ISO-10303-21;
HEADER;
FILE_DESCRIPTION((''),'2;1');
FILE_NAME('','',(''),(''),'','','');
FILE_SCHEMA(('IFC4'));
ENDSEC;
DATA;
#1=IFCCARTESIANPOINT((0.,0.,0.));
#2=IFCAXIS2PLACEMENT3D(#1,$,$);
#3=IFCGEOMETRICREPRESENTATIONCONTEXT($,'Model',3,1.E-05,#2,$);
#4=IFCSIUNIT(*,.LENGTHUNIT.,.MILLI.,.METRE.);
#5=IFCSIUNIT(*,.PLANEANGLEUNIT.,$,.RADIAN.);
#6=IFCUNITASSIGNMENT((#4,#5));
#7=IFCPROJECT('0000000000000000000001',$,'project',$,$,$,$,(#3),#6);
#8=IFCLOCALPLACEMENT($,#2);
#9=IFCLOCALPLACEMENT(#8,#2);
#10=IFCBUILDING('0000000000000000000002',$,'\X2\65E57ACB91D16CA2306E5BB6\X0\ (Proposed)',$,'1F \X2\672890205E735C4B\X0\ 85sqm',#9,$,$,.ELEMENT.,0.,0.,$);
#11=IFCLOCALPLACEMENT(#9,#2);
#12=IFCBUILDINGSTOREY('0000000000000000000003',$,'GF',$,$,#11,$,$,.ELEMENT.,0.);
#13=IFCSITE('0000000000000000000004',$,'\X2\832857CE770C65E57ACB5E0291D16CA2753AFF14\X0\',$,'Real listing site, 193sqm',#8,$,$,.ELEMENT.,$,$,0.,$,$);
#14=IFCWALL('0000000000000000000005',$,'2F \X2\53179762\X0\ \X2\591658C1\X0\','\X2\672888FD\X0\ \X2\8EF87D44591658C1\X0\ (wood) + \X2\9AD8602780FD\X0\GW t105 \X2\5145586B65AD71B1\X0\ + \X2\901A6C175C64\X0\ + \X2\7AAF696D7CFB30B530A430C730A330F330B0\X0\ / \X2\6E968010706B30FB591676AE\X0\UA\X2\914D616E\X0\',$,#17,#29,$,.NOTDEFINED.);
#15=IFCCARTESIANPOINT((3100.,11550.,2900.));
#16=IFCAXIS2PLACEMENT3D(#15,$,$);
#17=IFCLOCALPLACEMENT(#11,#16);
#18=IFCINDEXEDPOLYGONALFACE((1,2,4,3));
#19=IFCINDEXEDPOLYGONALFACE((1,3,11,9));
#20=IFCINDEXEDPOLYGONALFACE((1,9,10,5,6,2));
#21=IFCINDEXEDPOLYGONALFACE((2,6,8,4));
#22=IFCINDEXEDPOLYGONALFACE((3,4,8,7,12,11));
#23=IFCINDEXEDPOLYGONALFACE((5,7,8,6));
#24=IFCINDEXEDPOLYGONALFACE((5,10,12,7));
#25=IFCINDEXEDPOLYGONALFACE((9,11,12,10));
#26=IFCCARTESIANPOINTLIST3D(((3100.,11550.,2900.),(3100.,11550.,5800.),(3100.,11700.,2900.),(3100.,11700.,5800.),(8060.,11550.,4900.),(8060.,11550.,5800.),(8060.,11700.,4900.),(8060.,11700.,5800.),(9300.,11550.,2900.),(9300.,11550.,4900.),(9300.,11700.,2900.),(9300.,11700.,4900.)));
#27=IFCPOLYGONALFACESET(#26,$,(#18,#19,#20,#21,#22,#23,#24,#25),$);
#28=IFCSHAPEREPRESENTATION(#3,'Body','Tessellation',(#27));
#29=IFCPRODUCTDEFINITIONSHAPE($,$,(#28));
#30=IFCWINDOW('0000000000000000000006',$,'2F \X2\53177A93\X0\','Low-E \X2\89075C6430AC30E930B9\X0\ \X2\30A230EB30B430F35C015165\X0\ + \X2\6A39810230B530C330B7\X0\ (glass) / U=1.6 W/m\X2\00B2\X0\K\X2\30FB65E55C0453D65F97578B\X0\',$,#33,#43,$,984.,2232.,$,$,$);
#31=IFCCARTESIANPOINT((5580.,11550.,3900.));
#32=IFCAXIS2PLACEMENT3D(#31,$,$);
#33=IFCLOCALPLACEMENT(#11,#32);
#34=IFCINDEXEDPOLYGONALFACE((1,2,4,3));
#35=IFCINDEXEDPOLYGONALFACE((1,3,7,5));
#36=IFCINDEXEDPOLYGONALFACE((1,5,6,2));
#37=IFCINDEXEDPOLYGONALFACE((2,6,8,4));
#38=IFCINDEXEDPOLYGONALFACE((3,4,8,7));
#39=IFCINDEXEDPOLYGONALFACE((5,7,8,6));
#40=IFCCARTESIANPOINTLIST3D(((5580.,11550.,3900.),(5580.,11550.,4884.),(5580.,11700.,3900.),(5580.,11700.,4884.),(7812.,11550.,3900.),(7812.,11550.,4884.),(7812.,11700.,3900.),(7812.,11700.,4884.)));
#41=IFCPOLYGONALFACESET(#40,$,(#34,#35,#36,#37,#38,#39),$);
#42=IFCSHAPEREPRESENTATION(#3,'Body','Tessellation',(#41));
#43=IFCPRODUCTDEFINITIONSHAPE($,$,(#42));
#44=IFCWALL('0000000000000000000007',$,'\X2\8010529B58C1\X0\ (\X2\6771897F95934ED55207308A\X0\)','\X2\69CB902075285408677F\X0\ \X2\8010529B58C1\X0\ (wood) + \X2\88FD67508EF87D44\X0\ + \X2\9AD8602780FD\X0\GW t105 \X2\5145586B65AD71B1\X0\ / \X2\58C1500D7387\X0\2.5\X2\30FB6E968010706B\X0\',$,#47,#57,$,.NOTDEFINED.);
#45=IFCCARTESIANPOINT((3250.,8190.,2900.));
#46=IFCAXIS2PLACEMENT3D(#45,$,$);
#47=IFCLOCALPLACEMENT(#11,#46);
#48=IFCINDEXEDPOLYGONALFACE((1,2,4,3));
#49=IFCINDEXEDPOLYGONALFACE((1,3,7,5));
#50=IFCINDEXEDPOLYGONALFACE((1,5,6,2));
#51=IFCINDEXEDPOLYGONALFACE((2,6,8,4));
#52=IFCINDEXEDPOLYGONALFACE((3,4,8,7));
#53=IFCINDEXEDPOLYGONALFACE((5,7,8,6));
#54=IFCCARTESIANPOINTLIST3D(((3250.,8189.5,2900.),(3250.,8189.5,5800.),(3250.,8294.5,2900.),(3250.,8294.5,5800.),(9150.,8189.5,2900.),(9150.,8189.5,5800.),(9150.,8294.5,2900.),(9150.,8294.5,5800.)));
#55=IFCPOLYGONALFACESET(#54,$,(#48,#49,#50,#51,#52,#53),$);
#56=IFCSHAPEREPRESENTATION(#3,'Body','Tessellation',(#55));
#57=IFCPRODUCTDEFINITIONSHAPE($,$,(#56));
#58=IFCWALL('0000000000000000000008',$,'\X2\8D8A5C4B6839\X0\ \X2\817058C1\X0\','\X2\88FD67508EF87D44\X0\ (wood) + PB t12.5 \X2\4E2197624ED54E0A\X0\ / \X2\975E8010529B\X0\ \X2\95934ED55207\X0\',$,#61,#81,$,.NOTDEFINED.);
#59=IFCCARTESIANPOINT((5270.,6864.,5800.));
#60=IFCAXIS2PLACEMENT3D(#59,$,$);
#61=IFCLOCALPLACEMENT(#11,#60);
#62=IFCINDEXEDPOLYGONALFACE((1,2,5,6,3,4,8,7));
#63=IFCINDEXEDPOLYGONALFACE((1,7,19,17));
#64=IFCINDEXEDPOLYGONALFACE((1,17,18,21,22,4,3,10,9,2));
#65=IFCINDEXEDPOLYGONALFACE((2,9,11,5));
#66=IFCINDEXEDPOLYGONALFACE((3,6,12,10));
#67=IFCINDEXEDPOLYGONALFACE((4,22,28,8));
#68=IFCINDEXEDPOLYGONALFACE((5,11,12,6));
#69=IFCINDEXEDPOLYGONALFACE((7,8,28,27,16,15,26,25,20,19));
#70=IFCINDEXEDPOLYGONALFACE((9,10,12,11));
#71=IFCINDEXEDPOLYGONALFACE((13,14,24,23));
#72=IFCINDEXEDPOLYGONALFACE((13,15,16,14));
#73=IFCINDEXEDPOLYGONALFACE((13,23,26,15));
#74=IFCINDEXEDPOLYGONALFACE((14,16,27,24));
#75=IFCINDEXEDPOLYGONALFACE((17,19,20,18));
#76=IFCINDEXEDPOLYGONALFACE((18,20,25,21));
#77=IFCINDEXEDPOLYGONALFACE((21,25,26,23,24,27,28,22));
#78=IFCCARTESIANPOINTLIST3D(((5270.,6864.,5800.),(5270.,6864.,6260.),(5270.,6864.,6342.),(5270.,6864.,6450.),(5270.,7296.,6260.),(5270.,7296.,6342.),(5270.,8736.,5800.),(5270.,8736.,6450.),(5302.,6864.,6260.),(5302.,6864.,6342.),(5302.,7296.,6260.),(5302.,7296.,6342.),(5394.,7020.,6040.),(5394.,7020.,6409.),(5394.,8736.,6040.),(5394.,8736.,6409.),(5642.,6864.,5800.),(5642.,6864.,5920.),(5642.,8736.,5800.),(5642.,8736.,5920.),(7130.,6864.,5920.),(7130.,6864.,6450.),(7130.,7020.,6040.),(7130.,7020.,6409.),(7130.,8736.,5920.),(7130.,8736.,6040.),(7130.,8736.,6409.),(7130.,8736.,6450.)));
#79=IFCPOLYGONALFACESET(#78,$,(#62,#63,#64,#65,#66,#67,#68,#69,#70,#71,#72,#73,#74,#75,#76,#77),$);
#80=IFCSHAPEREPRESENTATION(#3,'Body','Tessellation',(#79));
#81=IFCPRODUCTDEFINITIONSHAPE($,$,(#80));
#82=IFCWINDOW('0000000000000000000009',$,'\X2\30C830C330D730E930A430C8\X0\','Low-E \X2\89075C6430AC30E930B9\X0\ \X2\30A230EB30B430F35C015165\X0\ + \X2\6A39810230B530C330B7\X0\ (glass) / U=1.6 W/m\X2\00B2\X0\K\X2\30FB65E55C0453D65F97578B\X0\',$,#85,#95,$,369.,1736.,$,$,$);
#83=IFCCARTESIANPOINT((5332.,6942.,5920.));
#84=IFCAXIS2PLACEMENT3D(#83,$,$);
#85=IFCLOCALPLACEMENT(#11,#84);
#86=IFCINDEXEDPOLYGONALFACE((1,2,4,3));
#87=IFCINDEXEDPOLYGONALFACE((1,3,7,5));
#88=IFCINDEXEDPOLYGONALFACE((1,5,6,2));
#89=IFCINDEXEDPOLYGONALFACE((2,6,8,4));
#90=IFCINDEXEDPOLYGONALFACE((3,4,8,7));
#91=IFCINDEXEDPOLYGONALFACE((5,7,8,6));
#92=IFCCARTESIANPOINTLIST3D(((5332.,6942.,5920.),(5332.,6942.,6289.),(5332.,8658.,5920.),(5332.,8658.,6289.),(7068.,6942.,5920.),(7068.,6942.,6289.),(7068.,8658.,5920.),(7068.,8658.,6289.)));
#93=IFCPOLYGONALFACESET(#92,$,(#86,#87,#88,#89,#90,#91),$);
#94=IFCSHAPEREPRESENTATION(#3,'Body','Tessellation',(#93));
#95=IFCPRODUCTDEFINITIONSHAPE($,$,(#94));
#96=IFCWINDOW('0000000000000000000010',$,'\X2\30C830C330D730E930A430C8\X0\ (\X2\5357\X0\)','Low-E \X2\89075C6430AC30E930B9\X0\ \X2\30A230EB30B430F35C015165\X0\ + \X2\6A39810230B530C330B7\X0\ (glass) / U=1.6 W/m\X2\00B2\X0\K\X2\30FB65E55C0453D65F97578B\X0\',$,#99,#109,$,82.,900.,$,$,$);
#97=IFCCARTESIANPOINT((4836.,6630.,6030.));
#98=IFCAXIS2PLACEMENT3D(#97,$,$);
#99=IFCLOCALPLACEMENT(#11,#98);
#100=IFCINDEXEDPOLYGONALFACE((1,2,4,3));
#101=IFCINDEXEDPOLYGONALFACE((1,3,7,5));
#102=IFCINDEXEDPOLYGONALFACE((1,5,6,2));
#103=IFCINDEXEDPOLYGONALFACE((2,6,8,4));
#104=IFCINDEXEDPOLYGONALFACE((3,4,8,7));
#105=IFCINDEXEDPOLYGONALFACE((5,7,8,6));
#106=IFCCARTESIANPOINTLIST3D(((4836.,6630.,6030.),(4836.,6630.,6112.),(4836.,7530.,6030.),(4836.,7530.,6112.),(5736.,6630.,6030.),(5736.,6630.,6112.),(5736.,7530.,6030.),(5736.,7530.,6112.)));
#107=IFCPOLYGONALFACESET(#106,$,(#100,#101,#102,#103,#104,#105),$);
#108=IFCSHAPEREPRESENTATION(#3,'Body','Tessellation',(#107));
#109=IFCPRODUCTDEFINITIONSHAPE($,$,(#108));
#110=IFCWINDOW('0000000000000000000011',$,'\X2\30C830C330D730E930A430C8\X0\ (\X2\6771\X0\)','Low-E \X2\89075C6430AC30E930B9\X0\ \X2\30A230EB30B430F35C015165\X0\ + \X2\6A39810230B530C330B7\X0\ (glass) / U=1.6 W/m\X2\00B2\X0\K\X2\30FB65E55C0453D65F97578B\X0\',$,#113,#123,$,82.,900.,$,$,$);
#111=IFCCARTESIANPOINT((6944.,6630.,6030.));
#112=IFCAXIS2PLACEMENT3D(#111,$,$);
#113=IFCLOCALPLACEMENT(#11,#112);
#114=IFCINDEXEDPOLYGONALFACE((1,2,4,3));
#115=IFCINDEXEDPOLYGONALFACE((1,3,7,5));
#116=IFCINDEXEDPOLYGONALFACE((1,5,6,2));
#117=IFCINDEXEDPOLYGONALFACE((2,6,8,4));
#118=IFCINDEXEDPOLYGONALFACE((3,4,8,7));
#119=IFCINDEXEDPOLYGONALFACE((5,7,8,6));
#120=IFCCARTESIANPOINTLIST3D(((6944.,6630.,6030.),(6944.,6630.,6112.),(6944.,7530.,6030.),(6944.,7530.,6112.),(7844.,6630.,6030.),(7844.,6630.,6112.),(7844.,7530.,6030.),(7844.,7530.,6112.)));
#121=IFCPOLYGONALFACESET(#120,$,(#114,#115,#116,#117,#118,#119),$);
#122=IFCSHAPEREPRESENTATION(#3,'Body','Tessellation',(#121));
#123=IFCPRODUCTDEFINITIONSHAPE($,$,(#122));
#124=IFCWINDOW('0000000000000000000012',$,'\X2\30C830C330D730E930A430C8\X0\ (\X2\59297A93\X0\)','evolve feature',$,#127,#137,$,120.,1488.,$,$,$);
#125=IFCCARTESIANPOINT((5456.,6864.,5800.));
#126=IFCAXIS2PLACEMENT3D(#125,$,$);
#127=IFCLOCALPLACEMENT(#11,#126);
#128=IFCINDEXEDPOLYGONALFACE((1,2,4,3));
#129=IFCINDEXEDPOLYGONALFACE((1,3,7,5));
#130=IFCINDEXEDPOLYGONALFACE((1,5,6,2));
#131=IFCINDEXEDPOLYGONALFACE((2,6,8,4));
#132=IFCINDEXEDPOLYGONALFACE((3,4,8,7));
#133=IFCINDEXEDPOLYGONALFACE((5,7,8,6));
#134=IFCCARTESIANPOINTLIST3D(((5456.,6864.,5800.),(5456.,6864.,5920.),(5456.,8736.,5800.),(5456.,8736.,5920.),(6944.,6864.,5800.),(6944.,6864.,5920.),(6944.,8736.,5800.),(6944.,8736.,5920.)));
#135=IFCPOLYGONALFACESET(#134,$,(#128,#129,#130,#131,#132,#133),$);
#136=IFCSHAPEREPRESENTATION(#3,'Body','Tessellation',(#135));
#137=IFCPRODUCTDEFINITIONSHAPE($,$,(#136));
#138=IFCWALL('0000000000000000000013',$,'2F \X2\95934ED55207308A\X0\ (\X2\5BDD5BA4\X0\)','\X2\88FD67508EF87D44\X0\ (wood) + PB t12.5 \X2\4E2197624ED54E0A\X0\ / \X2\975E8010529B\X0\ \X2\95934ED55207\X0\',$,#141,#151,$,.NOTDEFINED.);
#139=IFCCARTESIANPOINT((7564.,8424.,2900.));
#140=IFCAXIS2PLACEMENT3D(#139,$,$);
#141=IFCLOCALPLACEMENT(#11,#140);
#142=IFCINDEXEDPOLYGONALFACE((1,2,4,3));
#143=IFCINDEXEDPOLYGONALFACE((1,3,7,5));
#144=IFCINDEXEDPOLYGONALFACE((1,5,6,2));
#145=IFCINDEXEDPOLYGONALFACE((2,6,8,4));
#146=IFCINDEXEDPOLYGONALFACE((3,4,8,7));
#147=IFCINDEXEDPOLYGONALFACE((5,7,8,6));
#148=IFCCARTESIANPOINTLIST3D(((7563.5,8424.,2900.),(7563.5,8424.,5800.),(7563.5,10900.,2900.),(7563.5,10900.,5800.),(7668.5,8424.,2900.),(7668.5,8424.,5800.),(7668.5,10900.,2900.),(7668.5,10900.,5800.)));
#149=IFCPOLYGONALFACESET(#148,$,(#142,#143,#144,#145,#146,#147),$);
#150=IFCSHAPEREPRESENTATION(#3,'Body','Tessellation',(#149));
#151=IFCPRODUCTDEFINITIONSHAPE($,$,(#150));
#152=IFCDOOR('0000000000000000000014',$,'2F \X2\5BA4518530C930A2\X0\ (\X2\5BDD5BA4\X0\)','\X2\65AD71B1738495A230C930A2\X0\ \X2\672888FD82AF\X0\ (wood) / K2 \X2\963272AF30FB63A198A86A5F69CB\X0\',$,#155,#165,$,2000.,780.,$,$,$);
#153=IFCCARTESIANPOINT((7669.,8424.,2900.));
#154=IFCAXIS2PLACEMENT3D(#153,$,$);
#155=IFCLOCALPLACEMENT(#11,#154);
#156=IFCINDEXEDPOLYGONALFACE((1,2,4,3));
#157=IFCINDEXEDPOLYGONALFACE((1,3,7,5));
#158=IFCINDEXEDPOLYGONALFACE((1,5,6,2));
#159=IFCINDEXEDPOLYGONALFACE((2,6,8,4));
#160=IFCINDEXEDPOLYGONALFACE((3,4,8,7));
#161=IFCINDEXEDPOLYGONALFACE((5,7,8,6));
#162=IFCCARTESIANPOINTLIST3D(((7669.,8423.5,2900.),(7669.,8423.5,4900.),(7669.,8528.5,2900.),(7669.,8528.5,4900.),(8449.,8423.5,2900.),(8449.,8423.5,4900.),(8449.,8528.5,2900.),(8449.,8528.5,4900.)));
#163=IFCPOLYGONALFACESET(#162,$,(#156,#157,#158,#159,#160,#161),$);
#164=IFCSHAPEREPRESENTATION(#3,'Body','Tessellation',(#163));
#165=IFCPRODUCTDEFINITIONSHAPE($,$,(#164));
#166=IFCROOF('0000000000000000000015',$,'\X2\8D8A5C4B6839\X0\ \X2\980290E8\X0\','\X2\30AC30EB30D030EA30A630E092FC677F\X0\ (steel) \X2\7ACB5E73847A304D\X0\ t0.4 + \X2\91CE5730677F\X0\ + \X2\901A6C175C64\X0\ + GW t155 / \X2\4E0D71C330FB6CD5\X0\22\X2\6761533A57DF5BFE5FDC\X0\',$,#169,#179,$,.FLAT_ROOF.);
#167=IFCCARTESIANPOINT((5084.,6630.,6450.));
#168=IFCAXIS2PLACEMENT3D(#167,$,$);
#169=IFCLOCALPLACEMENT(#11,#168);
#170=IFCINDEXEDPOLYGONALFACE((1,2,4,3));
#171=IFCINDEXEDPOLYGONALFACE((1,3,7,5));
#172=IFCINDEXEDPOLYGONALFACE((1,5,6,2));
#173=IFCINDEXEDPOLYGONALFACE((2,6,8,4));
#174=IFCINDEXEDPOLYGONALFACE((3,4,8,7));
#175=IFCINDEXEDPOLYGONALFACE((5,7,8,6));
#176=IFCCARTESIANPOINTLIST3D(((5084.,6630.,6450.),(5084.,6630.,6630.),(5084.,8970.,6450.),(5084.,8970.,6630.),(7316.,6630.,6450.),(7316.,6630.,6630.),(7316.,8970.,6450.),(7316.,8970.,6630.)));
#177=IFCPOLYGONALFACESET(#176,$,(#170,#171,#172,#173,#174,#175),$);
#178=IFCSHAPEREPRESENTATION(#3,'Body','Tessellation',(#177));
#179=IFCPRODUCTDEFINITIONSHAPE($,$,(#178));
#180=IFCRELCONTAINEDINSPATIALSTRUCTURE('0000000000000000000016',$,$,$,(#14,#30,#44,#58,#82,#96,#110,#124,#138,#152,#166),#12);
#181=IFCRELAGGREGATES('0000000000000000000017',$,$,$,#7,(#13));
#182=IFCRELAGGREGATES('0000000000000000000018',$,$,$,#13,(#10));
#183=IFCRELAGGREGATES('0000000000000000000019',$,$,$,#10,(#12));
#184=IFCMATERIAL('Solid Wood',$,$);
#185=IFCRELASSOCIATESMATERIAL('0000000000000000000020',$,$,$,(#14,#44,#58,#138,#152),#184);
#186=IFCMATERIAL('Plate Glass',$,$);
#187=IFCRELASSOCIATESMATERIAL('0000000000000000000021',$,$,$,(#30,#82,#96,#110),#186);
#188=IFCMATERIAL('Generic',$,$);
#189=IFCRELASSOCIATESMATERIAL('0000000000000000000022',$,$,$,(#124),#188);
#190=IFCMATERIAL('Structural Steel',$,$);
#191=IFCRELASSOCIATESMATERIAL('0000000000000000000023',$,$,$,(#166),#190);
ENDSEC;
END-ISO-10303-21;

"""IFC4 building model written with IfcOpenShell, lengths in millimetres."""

from ifc_helpers import new_model, si_unit, frame, frame_2d, origin, place, context, project, spatial, rectangle, extrude, material, element, fill, save


model = new_model("IFC4")

# Units and contexts
model_context = context("Model", 3, precision=1e-05, world=origin())
ifc_project = project(units=[si_unit("LENGTHUNIT", "METRE", prefix="MILLI"), si_unit("PLANEANGLEUNIT", "RADIAN")], contexts=[model_context])

# Site, building, storey
site_placement = place(None, origin())
site = spatial("IfcSite", under=ifc_project, at=site_placement, Name="茨城県日立市金沢町４", ObjectType="Real listing site, 193sqm", CompositionType="ELEMENT", RefElevation=0.0)
building_placement = place(site_placement, origin())
building = spatial("IfcBuilding", under=site, at=building_placement, Name="日立金沢の家 (Proposed)", ObjectType="1F 木造平屋 85sqm", CompositionType="ELEMENT", ElevationOfRefHeight=0.0, ElevationOfTerrain=0.0)
storey_placement = place(building_placement, origin())
storey = spatial("IfcBuildingStorey", under=building, at=storey_placement, Name="GF", CompositionType="ELEMENT", Elevation=0.0)

# Wall, opening, window
ifc_material_1 = material(Name="Solid Wood")
wall_1_placement = place(storey_placement, frame((3100.0, 11550.0, 2900.0)))
wall_1 = element("IfcWall", 1, at=wall_1_placement, inside=storey, material=ifc_material_1, Name="2F 北面 外壁", Description="木製 軸組外壁 (wood) + 高性能GW t105 充填断熱 + 通気層 + 窯業系サイディング / 準耐火・外皮UA配慮", PredefinedType="NOTDEFINED", context=model_context, shape_type="SweptSolid", body=[
    extrude(rectangle(XDim=6200.0, YDim=150.0, at=frame_2d((3100.0, 75.0))), frame((3100.0, 11550.0, 2900.0)), (0.0, 0.0, 1.0), 2900.0),
])
opening_1_placement = place(storey_placement, frame((5580.0, 11550.0, 3900.0)))
opening_1 = element("IfcOpeningElement", 2, at=opening_1_placement, cuts=wall_1, PredefinedType="NOTDEFINED", context=model_context, shape_type="SweptSolid", body=[
    extrude(rectangle(XDim=2232.0, YDim=150.0, at=frame_2d((1116.0, 75.0))), frame((5580.0, 11550.0, 3900.0)), (0.0, 0.0, 1.0), 984.0),
])
ifc_material_2 = material(Name="Plate Glass")
window_1_placement = place(storey_placement, frame((5580.0, 11550.0, 3900.0)))
window_1 = element("IfcWindow", 3, at=window_1_placement, inside=storey, material=ifc_material_2, Name="2F 北窓", Description="Low-E 複層ガラス アルゴン封入 + 樹脂サッシ (glass) / U=1.6 W/m²K・日射取得型", OverallHeight=984.0, OverallWidth=2232.0, context=model_context, shape_type="SweptSolid", body=[
    extrude(rectangle(XDim=2232.0, YDim=150.0, at=frame_2d((1116.0, 75.0))), frame((5580.0, 11550.0, 3900.0)), (0.0, 0.0, 1.0), 984.0),
])
fill(opening_1, window_1)

# Wall
wall_2_placement = place(storey_placement, frame((3250.0, 8190.0, 2900.0)))
element("IfcWall", 4, at=wall_2_placement, inside=storey, material=ifc_material_1, Name="耐力壁 (東西間仕切り)", Description="構造用合板 耐力壁 (wood) + 製材軸組 + 高性能GW t105 充填断熱 / 壁倍率2.5・準耐火", PredefinedType="NOTDEFINED", context=model_context, shape_type="SweptSolid", body=[
    extrude(rectangle(XDim=5900.0, YDim=105.0, at=frame_2d((2950.0, 52.0))), frame((3250.0, 8190.0, 2900.0)), (0.0, 0.0, 1.0), 2900.0),
])

# Wall, openings, windows
wall_3_placement = place(storey_placement, frame((5270.0, 6864.0, 5800.0)))
wall_3 = element("IfcWall", 5, at=wall_3_placement, inside=storey, material=ifc_material_1, Name="越屋根 腰壁", Description="製材軸組 (wood) + PB t12.5 両面仕上 / 非耐力 間仕切", PredefinedType="NOTDEFINED", context=model_context, shape_type="SweptSolid", body=[
    extrude(rectangle(XDim=1860.0, YDim=1872.0, at=frame_2d((930.0, 936.0))), frame((5270.0, 6864.0, 5800.0)), (0.0, 0.0, 1.0), 650.0),
])
opening_2_placement = place(storey_placement, frame((5332.0, 6942.0, 5920.0)))
opening_2 = element("IfcOpeningElement", 6, at=opening_2_placement, cuts=wall_3, PredefinedType="NOTDEFINED", context=model_context, shape_type="SweptSolid", body=[
    extrude(rectangle(XDim=1736.0, YDim=1716.0, at=frame_2d((868.0, 858.0))), frame((5332.0, 6942.0, 5920.0)), (0.0, 0.0, 1.0), 369.0),
])
opening_3_placement = place(storey_placement, frame((4836.0, 6630.0, 6030.0)))
opening_3 = element("IfcOpeningElement", 7, at=opening_3_placement, cuts=wall_3, PredefinedType="NOTDEFINED", context=model_context, shape_type="SweptSolid", body=[
    extrude(rectangle(XDim=900.0, YDim=900.0, at=frame_2d((450.0, 450.0))), frame((4836.0, 6630.0, 6030.0)), (0.0, 0.0, 1.0), 82.0),
])
opening_4_placement = place(storey_placement, frame((6944.0, 6630.0, 6030.0)))
opening_4 = element("IfcOpeningElement", 8, at=opening_4_placement, cuts=wall_3, PredefinedType="NOTDEFINED", context=model_context, shape_type="SweptSolid", body=[
    extrude(rectangle(XDim=900.0, YDim=900.0, at=frame_2d((450.0, 450.0))), frame((6944.0, 6630.0, 6030.0)), (0.0, 0.0, 1.0), 82.0),
])
opening_5_placement = place(storey_placement, frame((5456.0, 6864.0, 5800.0)))
opening_5 = element("IfcOpeningElement", 9, at=opening_5_placement, cuts=wall_3, PredefinedType="NOTDEFINED", context=model_context, shape_type="SweptSolid", body=[
    extrude(rectangle(XDim=1488.0, YDim=1872.0, at=frame_2d((744.0, 936.0))), frame((5456.0, 6864.0, 5800.0)), (0.0, 0.0, 1.0), 120.0),
])
window_2_placement = place(storey_placement, frame((5332.0, 6942.0, 5920.0)))
window_2 = element("IfcWindow", 10, at=window_2_placement, inside=storey, material=ifc_material_2, Name="トップライト", Description="Low-E 複層ガラス アルゴン封入 + 樹脂サッシ (glass) / U=1.6 W/m²K・日射取得型", OverallHeight=369.0, OverallWidth=1736.0, context=model_context, shape_type="SweptSolid", body=[
    extrude(rectangle(XDim=1736.0, YDim=1716.0, at=frame_2d((868.0, 858.0))), frame((5332.0, 6942.0, 5920.0)), (0.0, 0.0, 1.0), 369.0),
])
fill(opening_2, window_2)
window_3_placement = place(storey_placement, frame((4836.0, 6630.0, 6030.0)))
window_3 = element("IfcWindow", 11, at=window_3_placement, inside=storey, material=ifc_material_2, Name="トップライト (南)", Description="Low-E 複層ガラス アルゴン封入 + 樹脂サッシ (glass) / U=1.6 W/m²K・日射取得型", OverallHeight=82.0, OverallWidth=900.0, context=model_context, shape_type="SweptSolid", body=[
    extrude(rectangle(XDim=900.0, YDim=900.0, at=frame_2d((450.0, 450.0))), frame((4836.0, 6630.0, 6030.0)), (0.0, 0.0, 1.0), 82.0),
])
fill(opening_3, window_3)
window_4_placement = place(storey_placement, frame((6944.0, 6630.0, 6030.0)))
window_4 = element("IfcWindow", 12, at=window_4_placement, inside=storey, material=ifc_material_2, Name="トップライト (東)", Description="Low-E 複層ガラス アルゴン封入 + 樹脂サッシ (glass) / U=1.6 W/m²K・日射取得型", OverallHeight=82.0, OverallWidth=900.0, context=model_context, shape_type="SweptSolid", body=[
    extrude(rectangle(XDim=900.0, YDim=900.0, at=frame_2d((450.0, 450.0))), frame((6944.0, 6630.0, 6030.0)), (0.0, 0.0, 1.0), 82.0),
])
fill(opening_4, window_4)
ifc_material_3 = material(Name="Generic")
window_5_placement = place(storey_placement, frame((5456.0, 6864.0, 5800.0)))
window_5 = element("IfcWindow", 13, at=window_5_placement, inside=storey, material=ifc_material_3, Name="トップライト (天窓)", Description="evolve feature", OverallHeight=120.0, OverallWidth=1488.0, context=model_context, shape_type="SweptSolid", body=[
    extrude(rectangle(XDim=1488.0, YDim=1872.0, at=frame_2d((744.0, 936.0))), frame((5456.0, 6864.0, 5800.0)), (0.0, 0.0, 1.0), 120.0),
])
fill(opening_5, window_5)

# Wall
wall_4_placement = place(storey_placement, frame((7564.0, 8424.0, 2900.0)))
element("IfcWall", 14, at=wall_4_placement, inside=storey, material=ifc_material_1, Name="2F 間仕切り (寝室)", Description="製材軸組 (wood) + PB t12.5 両面仕上 / 非耐力 間仕切", PredefinedType="NOTDEFINED", context=model_context, shape_type="SweptSolid", body=[
    extrude(rectangle(XDim=105.0, YDim=2476.0, at=frame_2d((52.0, 1238.0))), frame((7564.0, 8424.0, 2900.0)), (0.0, 0.0, 1.0), 2900.0),
])

# Door
door_placement = place(storey_placement, frame((7669.0, 8424.0, 2900.0)))
element("IfcDoor", 15, at=door_placement, inside=storey, material=ifc_material_1, Name="2F 室内ドア (寝室)", Description="断熱玄関ドア 木製芯 (wood) / K2 防犯・採風機構", OverallHeight=2000.0, OverallWidth=780.0, context=model_context, shape_type="SweptSolid", body=[
    extrude(rectangle(XDim=780.0, YDim=105.0, at=frame_2d((390.0, 52.0))), frame((7669.0, 8424.0, 2900.0)), (0.0, 0.0, 1.0), 2000.0),
])

# Roof
ifc_material_4 = material(Name="Structural Steel")
roof_placement = place(storey_placement, frame((5084.0, 6630.0, 6450.0)))
element("IfcRoof", 16, at=roof_placement, inside=storey, material=ifc_material_4, Name="越屋根 頂部", Description="ガルバリウム鋼板 (steel) 立平葺き t0.4 + 野地板 + 通気層 + GW t155 / 不燃・法22条区域対応", PredefinedType="FLAT_ROOF", context=model_context, shape_type="SweptSolid", body=[
    extrude(rectangle(XDim=2232.0, YDim=2340.0, at=frame_2d((1116.0, 1170.0))), frame((5084.0, 6630.0, 6450.0)), (0.0, 0.0, 1.0), 180.0),
])

save(model, "model.ifc")
